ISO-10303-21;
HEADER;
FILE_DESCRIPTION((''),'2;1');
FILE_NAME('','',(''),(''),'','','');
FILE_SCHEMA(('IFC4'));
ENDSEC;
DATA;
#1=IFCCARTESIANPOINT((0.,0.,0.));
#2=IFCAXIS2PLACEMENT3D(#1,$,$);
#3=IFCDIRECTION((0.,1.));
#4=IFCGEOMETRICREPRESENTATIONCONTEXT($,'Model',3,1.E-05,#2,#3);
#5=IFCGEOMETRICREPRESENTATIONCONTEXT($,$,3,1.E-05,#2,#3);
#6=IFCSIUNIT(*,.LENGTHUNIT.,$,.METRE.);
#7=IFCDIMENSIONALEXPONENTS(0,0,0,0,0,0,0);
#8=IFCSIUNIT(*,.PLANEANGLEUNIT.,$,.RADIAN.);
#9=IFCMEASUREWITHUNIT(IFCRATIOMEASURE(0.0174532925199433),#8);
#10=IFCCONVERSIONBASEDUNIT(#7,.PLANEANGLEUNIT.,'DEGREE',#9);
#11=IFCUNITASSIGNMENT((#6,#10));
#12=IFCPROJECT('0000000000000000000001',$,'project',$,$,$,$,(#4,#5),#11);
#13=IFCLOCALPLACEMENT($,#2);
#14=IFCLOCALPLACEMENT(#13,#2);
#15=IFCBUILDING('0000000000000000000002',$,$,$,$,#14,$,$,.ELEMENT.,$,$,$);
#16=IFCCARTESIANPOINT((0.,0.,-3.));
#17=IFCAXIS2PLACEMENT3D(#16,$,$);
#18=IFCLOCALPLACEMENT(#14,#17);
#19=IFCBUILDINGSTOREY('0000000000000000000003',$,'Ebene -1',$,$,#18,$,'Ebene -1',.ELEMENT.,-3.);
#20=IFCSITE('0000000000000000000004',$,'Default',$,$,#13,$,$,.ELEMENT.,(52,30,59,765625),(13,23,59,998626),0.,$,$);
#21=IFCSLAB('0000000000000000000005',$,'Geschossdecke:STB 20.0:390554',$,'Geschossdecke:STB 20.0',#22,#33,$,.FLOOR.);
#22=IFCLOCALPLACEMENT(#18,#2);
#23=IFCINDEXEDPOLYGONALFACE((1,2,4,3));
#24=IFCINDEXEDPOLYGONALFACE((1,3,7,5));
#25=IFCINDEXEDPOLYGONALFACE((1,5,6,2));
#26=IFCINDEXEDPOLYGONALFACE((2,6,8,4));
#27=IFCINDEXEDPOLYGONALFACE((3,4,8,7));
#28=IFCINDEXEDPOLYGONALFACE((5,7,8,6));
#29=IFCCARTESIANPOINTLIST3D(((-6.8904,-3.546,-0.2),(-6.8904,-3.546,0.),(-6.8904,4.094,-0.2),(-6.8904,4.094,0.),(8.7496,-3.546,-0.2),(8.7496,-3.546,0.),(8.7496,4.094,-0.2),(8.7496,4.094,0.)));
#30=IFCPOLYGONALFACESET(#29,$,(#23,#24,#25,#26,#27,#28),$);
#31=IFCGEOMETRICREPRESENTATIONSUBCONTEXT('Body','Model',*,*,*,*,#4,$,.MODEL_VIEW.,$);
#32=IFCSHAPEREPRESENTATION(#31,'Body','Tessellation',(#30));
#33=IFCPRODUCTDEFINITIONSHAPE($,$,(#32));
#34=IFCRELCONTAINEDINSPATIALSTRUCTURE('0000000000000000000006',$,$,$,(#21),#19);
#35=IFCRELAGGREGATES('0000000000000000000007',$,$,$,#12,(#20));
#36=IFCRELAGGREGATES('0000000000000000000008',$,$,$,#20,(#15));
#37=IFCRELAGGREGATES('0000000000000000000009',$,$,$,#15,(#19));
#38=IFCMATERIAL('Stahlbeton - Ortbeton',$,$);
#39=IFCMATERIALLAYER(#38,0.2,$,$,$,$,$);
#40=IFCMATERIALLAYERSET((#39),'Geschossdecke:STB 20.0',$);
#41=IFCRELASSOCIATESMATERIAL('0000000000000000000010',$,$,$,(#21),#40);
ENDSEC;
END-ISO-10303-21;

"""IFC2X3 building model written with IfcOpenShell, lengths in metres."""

from ifc_helpers import new_model, entity, si_unit, converted_unit, direction, frame, frame_2d, origin, place, context, subcontext, project, spatial, rectangle, extrude, material, layer, layer_set, layer_usage, element, save


model = new_model("IFC2X3")

# Units and contexts
model_context = context("Model", 3, precision=1e-05, world=origin(), true_north=direction((0.0, 1.0)))
context_of_model = context(None, 3, precision=1e-05, world=origin(), true_north=direction((0.0, 1.0)))
body_context = subcontext(model_context, "Body", "Model", "MODEL_VIEW")
ifc_project = project(units=[si_unit("LENGTHUNIT", "METRE"), converted_unit("PLANEANGLEUNIT", "DEGREE", entity("IfcRatioMeasure", 0.0174532925199433), si_unit("PLANEANGLEUNIT", "RADIAN"), dimensions=[0, 0, 0, 0, 0, 0, 0])], contexts=[model_context, context_of_model])

# Site, building, storey
site_placement = place(None, origin())
site = spatial("IfcSite", under=ifc_project, at=site_placement, Name="Default", CompositionType="ELEMENT", RefLatitude=(52, 30, 59, 765625), RefLongitude=(13, 23, 59, 998626), RefElevation=0.0)
building_placement = place(site_placement, origin())
building = spatial("IfcBuilding", under=site, at=building_placement, CompositionType="ELEMENT")
storey_placement = place(building_placement, frame((0.0, 0.0, -3.0)))
storey = spatial("IfcBuildingStorey", under=building, at=storey_placement, Name="Ebene -1", LongName="Ebene -1", CompositionType="ELEMENT", Elevation=-3.0)

# Slab
ifc_material = material(Name="Stahlbeton - Ortbeton")
ifc_layer = layer(ifc_material, 0.2)
ifc_layer_set = layer_set([ifc_layer], Name="Geschossdecke:STB 20.0")
ifc_layer_usage = layer_usage(ifc_layer_set, "AXIS3", "POSITIVE", 0.0)
slab_placement = place(storey_placement, origin())
element("IfcSlab", 1, at=slab_placement, inside=storey, material=ifc_layer_usage, Name="Geschossdecke:STB 20.0:390554", ObjectType="Geschossdecke:STB 20.0", PredefinedType="FLOOR", context=body_context, shape_type="SweptSolid", body=[
    extrude(rectangle(XDim=7.64, YDim=15.64, at=frame_2d((0.0, 0.0), x_axis=(1.0, 0.0))), frame((0.9296, 0.274, 0.0), z_axis=(0.0, 0.0, -1.0), x_axis=(0.0, 1.0, 0.0)), (0.0, 0.0, 1.0), 0.2),
])

save(model, "model.ifc")
